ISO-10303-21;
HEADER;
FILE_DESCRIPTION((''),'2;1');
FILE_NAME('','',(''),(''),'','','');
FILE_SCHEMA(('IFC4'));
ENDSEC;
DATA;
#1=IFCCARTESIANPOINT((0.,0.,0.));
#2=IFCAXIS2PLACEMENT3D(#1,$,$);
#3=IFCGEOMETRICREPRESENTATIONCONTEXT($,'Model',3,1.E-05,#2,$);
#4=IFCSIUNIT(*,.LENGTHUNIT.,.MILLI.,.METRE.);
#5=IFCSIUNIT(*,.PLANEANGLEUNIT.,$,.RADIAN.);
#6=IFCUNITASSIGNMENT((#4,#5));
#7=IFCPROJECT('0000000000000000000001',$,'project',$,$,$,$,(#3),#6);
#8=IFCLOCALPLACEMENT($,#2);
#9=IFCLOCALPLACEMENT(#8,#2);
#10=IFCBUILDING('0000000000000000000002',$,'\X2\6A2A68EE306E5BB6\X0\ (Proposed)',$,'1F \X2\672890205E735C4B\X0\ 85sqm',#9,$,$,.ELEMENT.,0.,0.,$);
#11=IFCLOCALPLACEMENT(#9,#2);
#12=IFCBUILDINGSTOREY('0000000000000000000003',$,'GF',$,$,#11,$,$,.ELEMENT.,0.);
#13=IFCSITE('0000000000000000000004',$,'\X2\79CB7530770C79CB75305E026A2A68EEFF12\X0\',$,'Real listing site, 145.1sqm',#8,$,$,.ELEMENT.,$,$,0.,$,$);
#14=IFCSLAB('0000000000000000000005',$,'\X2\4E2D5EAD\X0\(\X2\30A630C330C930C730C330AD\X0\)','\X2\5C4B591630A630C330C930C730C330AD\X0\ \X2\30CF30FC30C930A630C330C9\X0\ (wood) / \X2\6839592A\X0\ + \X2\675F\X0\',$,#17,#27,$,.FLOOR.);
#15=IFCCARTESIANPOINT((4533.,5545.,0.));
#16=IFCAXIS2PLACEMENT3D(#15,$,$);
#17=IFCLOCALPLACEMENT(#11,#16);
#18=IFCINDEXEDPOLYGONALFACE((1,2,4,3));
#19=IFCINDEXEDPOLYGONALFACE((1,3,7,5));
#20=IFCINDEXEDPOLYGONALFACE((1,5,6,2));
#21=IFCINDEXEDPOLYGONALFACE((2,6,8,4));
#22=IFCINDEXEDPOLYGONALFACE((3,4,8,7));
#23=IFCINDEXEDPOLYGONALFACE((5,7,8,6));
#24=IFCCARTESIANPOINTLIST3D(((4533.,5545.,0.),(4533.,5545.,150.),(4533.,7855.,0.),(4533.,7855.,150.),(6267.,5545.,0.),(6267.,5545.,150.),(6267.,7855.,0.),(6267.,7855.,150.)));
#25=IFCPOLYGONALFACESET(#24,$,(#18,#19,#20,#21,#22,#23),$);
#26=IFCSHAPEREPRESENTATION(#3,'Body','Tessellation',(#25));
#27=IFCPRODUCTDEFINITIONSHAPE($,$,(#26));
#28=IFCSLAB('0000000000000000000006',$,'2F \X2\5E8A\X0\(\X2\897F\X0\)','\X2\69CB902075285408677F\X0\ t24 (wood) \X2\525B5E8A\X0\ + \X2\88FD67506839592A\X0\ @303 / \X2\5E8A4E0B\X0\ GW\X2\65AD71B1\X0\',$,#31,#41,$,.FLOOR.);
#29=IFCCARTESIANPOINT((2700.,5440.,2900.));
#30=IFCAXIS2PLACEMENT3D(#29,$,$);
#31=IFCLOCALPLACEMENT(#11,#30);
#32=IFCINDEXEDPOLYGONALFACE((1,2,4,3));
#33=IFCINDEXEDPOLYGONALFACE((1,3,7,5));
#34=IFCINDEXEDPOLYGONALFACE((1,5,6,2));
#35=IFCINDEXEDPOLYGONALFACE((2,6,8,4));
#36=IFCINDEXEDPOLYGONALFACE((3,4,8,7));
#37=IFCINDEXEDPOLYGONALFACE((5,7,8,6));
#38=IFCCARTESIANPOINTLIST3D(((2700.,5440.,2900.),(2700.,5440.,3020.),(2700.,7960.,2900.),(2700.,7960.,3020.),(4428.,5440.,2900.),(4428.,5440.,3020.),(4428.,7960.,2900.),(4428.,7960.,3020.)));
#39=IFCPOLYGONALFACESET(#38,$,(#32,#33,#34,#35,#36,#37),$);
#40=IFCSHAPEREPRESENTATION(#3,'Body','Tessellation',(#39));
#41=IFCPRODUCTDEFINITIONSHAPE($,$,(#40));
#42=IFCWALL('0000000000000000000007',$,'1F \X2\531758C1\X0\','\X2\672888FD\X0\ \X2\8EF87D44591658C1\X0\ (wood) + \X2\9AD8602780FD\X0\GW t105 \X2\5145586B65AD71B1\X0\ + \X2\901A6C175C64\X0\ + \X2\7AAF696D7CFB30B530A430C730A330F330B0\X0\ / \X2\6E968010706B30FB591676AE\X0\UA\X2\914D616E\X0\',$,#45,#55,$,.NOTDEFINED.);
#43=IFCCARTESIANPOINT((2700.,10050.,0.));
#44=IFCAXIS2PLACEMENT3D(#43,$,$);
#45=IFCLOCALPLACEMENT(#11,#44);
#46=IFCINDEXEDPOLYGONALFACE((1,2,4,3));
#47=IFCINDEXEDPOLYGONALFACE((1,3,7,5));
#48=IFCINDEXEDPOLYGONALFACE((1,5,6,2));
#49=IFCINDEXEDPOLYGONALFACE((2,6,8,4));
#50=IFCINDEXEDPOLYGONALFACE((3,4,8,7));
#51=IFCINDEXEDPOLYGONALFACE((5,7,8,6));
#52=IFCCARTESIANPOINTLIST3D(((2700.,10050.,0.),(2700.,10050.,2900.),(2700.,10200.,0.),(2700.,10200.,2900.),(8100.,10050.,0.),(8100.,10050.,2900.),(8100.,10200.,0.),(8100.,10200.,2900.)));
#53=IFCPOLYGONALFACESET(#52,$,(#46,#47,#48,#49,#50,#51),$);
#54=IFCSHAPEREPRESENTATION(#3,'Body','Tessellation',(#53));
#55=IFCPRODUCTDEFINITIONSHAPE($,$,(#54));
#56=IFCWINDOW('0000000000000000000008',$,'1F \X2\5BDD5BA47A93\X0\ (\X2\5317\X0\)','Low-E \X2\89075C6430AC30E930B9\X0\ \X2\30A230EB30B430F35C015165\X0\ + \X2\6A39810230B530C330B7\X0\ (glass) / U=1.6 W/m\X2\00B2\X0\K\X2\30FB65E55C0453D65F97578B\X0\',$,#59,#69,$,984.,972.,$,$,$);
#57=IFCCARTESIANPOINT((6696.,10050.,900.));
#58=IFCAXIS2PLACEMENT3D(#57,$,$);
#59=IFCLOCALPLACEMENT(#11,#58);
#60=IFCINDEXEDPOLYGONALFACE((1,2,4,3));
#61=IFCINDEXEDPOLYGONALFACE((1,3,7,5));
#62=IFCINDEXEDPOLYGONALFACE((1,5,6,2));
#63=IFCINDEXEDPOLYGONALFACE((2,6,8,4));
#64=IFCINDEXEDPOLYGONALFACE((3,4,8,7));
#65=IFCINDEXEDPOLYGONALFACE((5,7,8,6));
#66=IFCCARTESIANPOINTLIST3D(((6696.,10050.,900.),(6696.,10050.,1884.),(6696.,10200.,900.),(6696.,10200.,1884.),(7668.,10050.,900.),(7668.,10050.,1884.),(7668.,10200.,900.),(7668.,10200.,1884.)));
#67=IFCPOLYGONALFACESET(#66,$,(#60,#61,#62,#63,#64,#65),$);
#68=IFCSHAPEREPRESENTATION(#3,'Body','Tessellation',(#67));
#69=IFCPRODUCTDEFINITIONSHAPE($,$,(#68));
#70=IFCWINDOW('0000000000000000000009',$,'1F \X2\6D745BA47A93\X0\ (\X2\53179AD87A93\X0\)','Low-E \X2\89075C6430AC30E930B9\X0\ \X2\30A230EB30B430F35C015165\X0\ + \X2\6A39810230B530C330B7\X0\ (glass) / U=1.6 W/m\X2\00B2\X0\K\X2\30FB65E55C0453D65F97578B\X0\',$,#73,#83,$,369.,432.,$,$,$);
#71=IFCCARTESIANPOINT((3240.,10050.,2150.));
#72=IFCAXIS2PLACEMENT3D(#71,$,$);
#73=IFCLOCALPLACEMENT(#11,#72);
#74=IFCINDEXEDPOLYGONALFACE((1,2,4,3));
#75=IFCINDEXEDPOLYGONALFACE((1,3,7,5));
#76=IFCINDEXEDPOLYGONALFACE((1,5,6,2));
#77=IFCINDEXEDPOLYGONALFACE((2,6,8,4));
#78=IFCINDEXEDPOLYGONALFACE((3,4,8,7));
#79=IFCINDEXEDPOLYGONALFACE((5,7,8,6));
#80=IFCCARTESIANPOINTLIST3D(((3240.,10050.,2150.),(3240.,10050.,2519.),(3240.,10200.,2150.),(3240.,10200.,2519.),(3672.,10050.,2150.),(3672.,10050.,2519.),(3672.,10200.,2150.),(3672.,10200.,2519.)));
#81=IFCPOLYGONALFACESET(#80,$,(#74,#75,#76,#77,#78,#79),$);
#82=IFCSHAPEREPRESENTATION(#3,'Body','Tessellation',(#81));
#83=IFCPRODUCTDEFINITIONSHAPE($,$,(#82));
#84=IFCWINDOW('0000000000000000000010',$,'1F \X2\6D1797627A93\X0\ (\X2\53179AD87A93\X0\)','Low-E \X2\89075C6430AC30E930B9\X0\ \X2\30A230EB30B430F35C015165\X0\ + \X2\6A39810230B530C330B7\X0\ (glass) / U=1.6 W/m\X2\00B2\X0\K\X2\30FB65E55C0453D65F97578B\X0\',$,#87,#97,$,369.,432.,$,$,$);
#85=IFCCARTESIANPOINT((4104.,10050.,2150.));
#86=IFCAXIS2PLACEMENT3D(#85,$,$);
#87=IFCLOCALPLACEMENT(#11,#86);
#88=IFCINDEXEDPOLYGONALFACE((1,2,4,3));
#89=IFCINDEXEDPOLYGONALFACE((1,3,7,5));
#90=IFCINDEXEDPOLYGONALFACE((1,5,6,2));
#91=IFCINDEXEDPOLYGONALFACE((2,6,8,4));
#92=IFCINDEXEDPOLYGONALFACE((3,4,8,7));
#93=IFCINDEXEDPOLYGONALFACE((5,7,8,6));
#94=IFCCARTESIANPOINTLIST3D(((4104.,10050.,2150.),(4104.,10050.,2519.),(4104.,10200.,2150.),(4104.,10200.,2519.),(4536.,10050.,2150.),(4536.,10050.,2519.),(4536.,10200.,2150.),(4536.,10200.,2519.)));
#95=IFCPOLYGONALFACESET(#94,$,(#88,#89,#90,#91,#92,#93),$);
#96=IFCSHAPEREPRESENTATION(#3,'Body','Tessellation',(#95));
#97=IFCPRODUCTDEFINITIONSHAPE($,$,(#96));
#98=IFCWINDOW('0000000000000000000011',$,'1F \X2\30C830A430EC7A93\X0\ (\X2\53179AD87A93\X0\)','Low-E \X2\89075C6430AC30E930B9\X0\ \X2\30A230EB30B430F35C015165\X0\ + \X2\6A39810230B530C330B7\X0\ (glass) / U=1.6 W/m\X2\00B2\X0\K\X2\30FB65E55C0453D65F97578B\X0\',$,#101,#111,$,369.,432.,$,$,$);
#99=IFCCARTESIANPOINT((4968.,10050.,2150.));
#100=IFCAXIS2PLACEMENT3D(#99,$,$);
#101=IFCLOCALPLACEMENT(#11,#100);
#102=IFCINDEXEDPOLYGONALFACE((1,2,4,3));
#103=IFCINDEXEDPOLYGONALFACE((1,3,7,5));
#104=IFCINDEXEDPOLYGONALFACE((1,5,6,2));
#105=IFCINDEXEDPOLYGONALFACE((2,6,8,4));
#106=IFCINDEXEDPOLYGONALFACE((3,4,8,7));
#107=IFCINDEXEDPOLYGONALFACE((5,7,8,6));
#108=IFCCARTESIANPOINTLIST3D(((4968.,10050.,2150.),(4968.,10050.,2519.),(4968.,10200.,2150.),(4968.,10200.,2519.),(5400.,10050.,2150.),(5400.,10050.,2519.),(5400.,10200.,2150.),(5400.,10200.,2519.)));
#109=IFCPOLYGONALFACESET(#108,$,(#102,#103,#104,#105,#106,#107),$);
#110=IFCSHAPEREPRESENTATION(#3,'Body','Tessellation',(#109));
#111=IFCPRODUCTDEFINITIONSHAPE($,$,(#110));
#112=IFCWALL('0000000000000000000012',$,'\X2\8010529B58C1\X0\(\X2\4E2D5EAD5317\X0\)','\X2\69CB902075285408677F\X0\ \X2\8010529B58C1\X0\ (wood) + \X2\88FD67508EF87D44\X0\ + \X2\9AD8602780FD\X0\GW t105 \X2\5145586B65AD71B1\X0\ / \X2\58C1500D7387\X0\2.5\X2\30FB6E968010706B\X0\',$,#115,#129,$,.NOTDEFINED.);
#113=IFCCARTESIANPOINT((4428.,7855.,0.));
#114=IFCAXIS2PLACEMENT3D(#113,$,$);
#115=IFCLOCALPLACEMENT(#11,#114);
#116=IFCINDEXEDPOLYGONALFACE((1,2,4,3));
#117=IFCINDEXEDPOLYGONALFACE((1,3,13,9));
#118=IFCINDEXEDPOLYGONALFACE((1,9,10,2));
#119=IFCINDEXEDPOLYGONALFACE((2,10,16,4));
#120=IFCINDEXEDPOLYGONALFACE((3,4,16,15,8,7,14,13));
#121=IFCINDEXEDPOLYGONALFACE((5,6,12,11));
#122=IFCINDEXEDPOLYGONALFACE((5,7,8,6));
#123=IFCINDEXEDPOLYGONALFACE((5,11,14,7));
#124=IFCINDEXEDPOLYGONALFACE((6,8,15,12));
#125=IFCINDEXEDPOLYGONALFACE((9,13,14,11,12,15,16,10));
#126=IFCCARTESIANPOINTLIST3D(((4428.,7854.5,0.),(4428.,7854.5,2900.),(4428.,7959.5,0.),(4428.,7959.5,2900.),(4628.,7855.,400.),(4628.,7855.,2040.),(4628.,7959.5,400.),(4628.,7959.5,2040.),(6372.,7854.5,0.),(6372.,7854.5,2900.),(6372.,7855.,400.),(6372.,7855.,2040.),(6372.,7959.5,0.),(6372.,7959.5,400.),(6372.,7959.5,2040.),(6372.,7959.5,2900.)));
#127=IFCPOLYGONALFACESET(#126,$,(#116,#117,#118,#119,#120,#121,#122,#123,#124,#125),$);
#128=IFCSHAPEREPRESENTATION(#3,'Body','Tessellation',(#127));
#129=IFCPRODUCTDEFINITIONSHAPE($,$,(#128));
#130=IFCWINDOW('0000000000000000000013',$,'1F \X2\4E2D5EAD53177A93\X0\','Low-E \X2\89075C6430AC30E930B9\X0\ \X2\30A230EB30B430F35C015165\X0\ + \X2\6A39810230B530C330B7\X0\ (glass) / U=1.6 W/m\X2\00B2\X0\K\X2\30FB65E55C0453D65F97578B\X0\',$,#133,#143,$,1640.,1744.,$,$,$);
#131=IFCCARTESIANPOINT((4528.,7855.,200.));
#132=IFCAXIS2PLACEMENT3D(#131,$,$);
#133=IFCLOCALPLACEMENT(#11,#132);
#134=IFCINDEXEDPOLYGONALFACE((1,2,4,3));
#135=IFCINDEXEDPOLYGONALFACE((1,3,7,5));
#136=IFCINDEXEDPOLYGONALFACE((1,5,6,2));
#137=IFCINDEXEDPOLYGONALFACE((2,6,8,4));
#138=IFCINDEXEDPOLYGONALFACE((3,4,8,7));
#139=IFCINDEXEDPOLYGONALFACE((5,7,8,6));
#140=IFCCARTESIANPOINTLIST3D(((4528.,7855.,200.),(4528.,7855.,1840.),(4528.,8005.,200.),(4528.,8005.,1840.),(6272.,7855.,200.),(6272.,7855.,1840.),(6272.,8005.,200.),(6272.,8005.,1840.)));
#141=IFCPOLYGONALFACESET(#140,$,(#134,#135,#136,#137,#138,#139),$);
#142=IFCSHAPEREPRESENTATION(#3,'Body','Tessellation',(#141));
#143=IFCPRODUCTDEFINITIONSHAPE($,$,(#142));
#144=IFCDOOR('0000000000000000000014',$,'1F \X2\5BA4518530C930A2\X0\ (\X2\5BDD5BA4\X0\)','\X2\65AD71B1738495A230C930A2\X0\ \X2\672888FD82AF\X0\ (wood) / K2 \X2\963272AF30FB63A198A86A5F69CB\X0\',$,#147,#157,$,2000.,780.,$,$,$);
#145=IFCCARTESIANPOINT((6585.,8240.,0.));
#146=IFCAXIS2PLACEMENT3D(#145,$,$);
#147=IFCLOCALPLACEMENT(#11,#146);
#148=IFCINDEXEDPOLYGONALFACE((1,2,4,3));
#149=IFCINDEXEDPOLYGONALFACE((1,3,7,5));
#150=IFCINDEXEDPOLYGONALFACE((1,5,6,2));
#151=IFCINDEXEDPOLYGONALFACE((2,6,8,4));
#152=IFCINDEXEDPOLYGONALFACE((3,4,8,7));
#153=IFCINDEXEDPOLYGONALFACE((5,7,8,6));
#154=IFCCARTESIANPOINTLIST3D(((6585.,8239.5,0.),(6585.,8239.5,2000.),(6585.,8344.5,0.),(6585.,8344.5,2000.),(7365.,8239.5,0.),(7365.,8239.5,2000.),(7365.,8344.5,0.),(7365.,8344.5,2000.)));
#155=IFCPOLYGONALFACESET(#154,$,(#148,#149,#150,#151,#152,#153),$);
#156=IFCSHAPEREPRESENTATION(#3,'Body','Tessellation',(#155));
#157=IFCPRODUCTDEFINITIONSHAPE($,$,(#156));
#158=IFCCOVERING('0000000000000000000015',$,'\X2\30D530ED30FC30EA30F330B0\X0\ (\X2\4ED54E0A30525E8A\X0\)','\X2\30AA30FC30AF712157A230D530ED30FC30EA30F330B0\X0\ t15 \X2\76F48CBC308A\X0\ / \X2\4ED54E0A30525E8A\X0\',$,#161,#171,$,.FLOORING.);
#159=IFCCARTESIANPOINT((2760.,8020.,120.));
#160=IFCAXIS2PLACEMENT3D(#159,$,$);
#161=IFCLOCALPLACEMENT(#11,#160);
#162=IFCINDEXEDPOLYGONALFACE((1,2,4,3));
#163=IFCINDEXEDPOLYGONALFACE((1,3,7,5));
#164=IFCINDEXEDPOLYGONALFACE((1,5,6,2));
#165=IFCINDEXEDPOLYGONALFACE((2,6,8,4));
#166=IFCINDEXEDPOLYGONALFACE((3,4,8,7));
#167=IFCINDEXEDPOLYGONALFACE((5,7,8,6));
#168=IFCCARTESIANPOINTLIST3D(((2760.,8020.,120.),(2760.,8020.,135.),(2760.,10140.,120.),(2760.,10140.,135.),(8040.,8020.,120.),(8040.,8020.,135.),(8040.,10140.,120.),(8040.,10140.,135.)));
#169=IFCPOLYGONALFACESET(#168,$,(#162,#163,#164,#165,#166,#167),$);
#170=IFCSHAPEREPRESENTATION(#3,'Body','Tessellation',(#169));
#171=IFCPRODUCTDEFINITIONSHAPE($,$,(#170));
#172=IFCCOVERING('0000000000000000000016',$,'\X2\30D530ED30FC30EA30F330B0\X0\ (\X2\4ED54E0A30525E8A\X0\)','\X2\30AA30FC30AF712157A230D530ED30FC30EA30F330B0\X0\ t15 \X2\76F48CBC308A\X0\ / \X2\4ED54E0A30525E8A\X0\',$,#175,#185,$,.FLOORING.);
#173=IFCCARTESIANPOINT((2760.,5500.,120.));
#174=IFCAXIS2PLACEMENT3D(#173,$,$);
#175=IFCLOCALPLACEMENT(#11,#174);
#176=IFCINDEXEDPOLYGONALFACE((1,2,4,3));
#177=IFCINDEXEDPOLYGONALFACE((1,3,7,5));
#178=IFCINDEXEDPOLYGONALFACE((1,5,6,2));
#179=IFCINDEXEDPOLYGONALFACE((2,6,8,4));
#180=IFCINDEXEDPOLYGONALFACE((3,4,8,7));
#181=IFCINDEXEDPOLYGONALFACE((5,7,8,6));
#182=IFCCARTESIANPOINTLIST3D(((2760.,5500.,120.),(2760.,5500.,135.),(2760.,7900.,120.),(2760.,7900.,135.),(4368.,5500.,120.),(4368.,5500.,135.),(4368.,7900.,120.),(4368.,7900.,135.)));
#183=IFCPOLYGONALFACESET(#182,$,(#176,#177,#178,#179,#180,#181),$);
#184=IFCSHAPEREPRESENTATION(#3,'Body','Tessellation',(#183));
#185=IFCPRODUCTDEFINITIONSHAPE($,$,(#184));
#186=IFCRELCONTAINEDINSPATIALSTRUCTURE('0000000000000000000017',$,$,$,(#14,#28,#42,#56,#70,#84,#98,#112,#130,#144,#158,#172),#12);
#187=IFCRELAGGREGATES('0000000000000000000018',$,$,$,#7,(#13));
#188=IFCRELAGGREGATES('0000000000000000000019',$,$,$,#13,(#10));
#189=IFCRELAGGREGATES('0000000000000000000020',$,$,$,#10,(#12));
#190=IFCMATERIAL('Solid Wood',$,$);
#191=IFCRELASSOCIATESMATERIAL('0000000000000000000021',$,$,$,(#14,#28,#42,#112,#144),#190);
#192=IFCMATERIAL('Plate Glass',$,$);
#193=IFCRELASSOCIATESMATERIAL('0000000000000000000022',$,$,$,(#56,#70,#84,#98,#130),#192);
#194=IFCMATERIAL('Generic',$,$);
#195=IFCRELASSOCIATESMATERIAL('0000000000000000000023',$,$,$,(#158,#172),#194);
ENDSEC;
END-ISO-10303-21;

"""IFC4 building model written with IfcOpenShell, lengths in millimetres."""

from ifc_helpers import new_model, si_unit, frame, frame_2d, origin, place, context, project, spatial, rectangle, extrude, material, element, fill, save


model = new_model("IFC4")

# Units and contexts
model_context = context("Model", 3, precision=1e-05, world=origin())
ifc_project = project(units=[si_unit("LENGTHUNIT", "METRE", prefix="MILLI"), si_unit("PLANEANGLEUNIT", "RADIAN")], contexts=[model_context])

# Site, building, storey
site_placement = place(None, origin())
site = spatial("IfcSite", under=ifc_project, at=site_placement, Name="秋田県秋田市横森２", ObjectType="Real listing site, 145.1sqm", CompositionType="ELEMENT", RefElevation=0.0)
building_placement = place(site_placement, origin())
building = spatial("IfcBuilding", under=site, at=building_placement, Name="横森の家 (Proposed)", ObjectType="1F 木造平屋 85sqm", CompositionType="ELEMENT", ElevationOfRefHeight=0.0, ElevationOfTerrain=0.0)
storey_placement = place(building_placement, origin())
storey = spatial("IfcBuildingStorey", under=building, at=storey_placement, Name="GF", CompositionType="ELEMENT", Elevation=0.0)

# Slabs
ifc_material_1 = material(Name="Solid Wood")
slab_1_placement = place(storey_placement, frame((4533.0, 5545.0, 0.0)))
element("IfcSlab", 1, at=slab_1_placement, inside=storey, material=ifc_material_1, Name="中庭(ウッドデッキ)", Description="屋外ウッドデッキ ハードウッド (wood) / 根太 + 束", PredefinedType="FLOOR", context=model_context, shape_type="SweptSolid", body=[
    extrude(rectangle(XDim=1734.0, YDim=2310.0, at=frame_2d((867.0, 1155.0))), frame((4533.0, 5545.0, 0.0)), (0.0, 0.0, 1.0), 150.0),
])
slab_2_placement = place(storey_placement, frame((2700.0, 5440.0, 2900.0)))
element("IfcSlab", 2, at=slab_2_placement, inside=storey, material=ifc_material_1, Name="2F 床(西)", Description="構造用合板 t24 (wood) 剛床 + 製材根太 @303 / 床下 GW断熱", PredefinedType="FLOOR", context=model_context, shape_type="SweptSolid", body=[
    extrude(rectangle(XDim=1728.0, YDim=2520.0, at=frame_2d((864.0, 1260.0))), frame((2700.0, 5440.0, 2900.0)), (0.0, 0.0, 1.0), 120.0),
])

# Wall, openings, windows
wall_1_placement = place(storey_placement, frame((2700.0, 10050.0, 0.0)))
wall_1 = element("IfcWall", 3, at=wall_1_placement, inside=storey, material=ifc_material_1, Name="1F 北壁", Description="木製 軸組外壁 (wood) + 高性能GW t105 充填断熱 + 通気層 + 窯業系サイディング / 準耐火・外皮UA配慮", PredefinedType="NOTDEFINED", context=model_context, shape_type="SweptSolid", body=[
    extrude(rectangle(XDim=5400.0, YDim=150.0, at=frame_2d((2700.0, 75.0))), frame((2700.0, 10050.0, 0.0)), (0.0, 0.0, 1.0), 2900.0),
])
opening_1_placement = place(storey_placement, frame((6696.0, 10050.0, 900.0)))
opening_1 = element("IfcOpeningElement", 4, at=opening_1_placement, cuts=wall_1, PredefinedType="NOTDEFINED", context=model_context, shape_type="SweptSolid", body=[
    extrude(rectangle(XDim=972.0, YDim=150.0, at=frame_2d((486.0, 75.0))), frame((6696.0, 10050.0, 900.0)), (0.0, 0.0, 1.0), 984.0),
])
opening_2_placement = place(storey_placement, frame((3240.0, 10050.0, 2150.0)))
opening_2 = element("IfcOpeningElement", 5, at=opening_2_placement, cuts=wall_1, PredefinedType="NOTDEFINED", context=model_context, shape_type="SweptSolid", body=[
    extrude(rectangle(XDim=432.0, YDim=150.0, at=frame_2d((216.0, 75.0))), frame((3240.0, 10050.0, 2150.0)), (0.0, 0.0, 1.0), 369.0),
])
opening_3_placement = place(storey_placement, frame((4104.0, 10050.0, 2150.0)))
opening_3 = element("IfcOpeningElement", 6, at=opening_3_placement, cuts=wall_1, PredefinedType="NOTDEFINED", context=model_context, shape_type="SweptSolid", body=[
    extrude(rectangle(XDim=432.0, YDim=150.0, at=frame_2d((216.0, 75.0))), frame((4104.0, 10050.0, 2150.0)), (0.0, 0.0, 1.0), 369.0),
])
opening_4_placement = place(storey_placement, frame((4968.0, 10050.0, 2150.0)))
opening_4 = element("IfcOpeningElement", 7, at=opening_4_placement, cuts=wall_1, PredefinedType="NOTDEFINED", context=model_context, shape_type="SweptSolid", body=[
    extrude(rectangle(XDim=432.0, YDim=150.0, at=frame_2d((216.0, 75.0))), frame((4968.0, 10050.0, 2150.0)), (0.0, 0.0, 1.0), 369.0),
])
ifc_material_2 = material(Name="Plate Glass")
window_1_placement = place(storey_placement, frame((6696.0, 10050.0, 900.0)))
window_1 = element("IfcWindow", 8, at=window_1_placement, inside=storey, material=ifc_material_2, Name="1F 寝室窓 (北)", Description="Low-E 複層ガラス アルゴン封入 + 樹脂サッシ (glass) / U=1.6 W/m²K・日射取得型", OverallHeight=984.0, OverallWidth=972.0, context=model_context, shape_type="SweptSolid", body=[
    extrude(rectangle(XDim=972.0, YDim=150.0, at=frame_2d((486.0, 75.0))), frame((6696.0, 10050.0, 900.0)), (0.0, 0.0, 1.0), 984.0),
])
fill(opening_1, window_1)
window_2_placement = place(storey_placement, frame((3240.0, 10050.0, 2150.0)))
window_2 = element("IfcWindow", 9, at=window_2_placement, inside=storey, material=ifc_material_2, Name="1F 浴室窓 (北高窓)", Description="Low-E 複層ガラス アルゴン封入 + 樹脂サッシ (glass) / U=1.6 W/m²K・日射取得型", OverallHeight=369.0, OverallWidth=432.0, context=model_context, shape_type="SweptSolid", body=[
    extrude(rectangle(XDim=432.0, YDim=150.0, at=frame_2d((216.0, 75.0))), frame((3240.0, 10050.0, 2150.0)), (0.0, 0.0, 1.0), 369.0),
])
fill(opening_2, window_2)
window_3_placement = place(storey_placement, frame((4104.0, 10050.0, 2150.0)))
window_3 = element("IfcWindow", 10, at=window_3_placement, inside=storey, material=ifc_material_2, Name="1F 洗面窓 (北高窓)", Description="Low-E 複層ガラス アルゴン封入 + 樹脂サッシ (glass) / U=1.6 W/m²K・日射取得型", OverallHeight=369.0, OverallWidth=432.0, context=model_context, shape_type="SweptSolid", body=[
    extrude(rectangle(XDim=432.0, YDim=150.0, at=frame_2d((216.0, 75.0))), frame((4104.0, 10050.0, 2150.0)), (0.0, 0.0, 1.0), 369.0),
])
fill(opening_3, window_3)
window_4_placement = place(storey_placement, frame((4968.0, 10050.0, 2150.0)))
window_4 = element("IfcWindow", 11, at=window_4_placement, inside=storey, material=ifc_material_2, Name="1F トイレ窓 (北高窓)", Description="Low-E 複層ガラス アルゴン封入 + 樹脂サッシ (glass) / U=1.6 W/m²K・日射取得型", OverallHeight=369.0, OverallWidth=432.0, context=model_context, shape_type="SweptSolid", body=[
    extrude(rectangle(XDim=432.0, YDim=150.0, at=frame_2d((216.0, 75.0))), frame((4968.0, 10050.0, 2150.0)), (0.0, 0.0, 1.0), 369.0),
])
fill(opening_4, window_4)

# Wall, opening, window
wall_2_placement = place(storey_placement, frame((4428.0, 7855.0, 0.0)))
wall_2 = element("IfcWall", 12, at=wall_2_placement, inside=storey, material=ifc_material_1, Name="耐力壁(中庭北)", Description="構造用合板 耐力壁 (wood) + 製材軸組 + 高性能GW t105 充填断熱 / 壁倍率2.5・準耐火", PredefinedType="NOTDEFINED", context=model_context, shape_type="SweptSolid", body=[
    extrude(rectangle(XDim=1944.0, YDim=105.0, at=frame_2d((972.0, 52.0))), frame((4428.0, 7855.0, 0.0)), (0.0, 0.0, 1.0), 2900.0),
])
opening_5_placement = place(storey_placement, frame((4528.0, 7855.0, 200.0)))
opening_5 = element("IfcOpeningElement", 13, at=opening_5_placement, cuts=wall_2, PredefinedType="NOTDEFINED", context=model_context, shape_type="SweptSolid", body=[
    extrude(rectangle(XDim=1744.0, YDim=150.0, at=frame_2d((872.0, 75.0))), frame((4528.0, 7855.0, 200.0)), (0.0, 0.0, 1.0), 1640.0),
])
window_5_placement = place(storey_placement, frame((4528.0, 7855.0, 200.0)))
window_5 = element("IfcWindow", 14, at=window_5_placement, inside=storey, material=ifc_material_2, Name="1F 中庭北窓", Description="Low-E 複層ガラス アルゴン封入 + 樹脂サッシ (glass) / U=1.6 W/m²K・日射取得型", OverallHeight=1640.0, OverallWidth=1744.0, context=model_context, shape_type="SweptSolid", body=[
    extrude(rectangle(XDim=1744.0, YDim=150.0, at=frame_2d((872.0, 75.0))), frame((4528.0, 7855.0, 200.0)), (0.0, 0.0, 1.0), 1640.0),
])
fill(opening_5, window_5)

# Door
door_1_placement = place(storey_placement, frame((6585.0, 8240.0, 0.0)))
element("IfcDoor", 15, at=door_1_placement, inside=storey, material=ifc_material_1, Name="1F 室内ドア (寝室)", Description="断熱玄関ドア 木製芯 (wood) / K2 防犯・採風機構", OverallHeight=2000.0, OverallWidth=780.0, context=model_context, shape_type="SweptSolid", body=[
    extrude(rectangle(XDim=780.0, YDim=105.0, at=frame_2d((390.0, 52.0))), frame((6585.0, 8240.0, 0.0)), (0.0, 0.0, 1.0), 2000.0),
])

# Coverings
ifc_material_3 = material(Name="Generic")
covering_1_placement = place(storey_placement, frame((2760.0, 8020.0, 120.0)))
element("IfcCovering", 16, at=covering_1_placement, inside=storey, material=ifc_material_3, Name="フローリング (仕上げ床)", Description="オーク無垢フローリング t15 直貼り / 仕上げ床", PredefinedType="FLOORING", context=model_context, shape_type="SweptSolid", body=[
    extrude(rectangle(XDim=5280.0, YDim=2120.0, at=frame_2d((2640.0, 1060.0))), frame((2760.0, 8020.0, 120.0)), (0.0, 0.0, 1.0), 15.0),
])
covering_2_placement = place(storey_placement, frame((2760.0, 5500.0, 120.0)))
element("IfcCovering", 17, at=covering_2_placement, inside=storey, material=ifc_material_3, Name="フローリング (仕上げ床)", Description="オーク無垢フローリング t15 直貼り / 仕上げ床", PredefinedType="FLOORING", context=model_context, shape_type="SweptSolid", body=[
    extrude(rectangle(XDim=1608.0, YDim=2400.0, at=frame_2d((804.0, 1200.0))), frame((2760.0, 5500.0, 120.0)), (0.0, 0.0, 1.0), 15.0),
])

save(model, "model.ifc")
